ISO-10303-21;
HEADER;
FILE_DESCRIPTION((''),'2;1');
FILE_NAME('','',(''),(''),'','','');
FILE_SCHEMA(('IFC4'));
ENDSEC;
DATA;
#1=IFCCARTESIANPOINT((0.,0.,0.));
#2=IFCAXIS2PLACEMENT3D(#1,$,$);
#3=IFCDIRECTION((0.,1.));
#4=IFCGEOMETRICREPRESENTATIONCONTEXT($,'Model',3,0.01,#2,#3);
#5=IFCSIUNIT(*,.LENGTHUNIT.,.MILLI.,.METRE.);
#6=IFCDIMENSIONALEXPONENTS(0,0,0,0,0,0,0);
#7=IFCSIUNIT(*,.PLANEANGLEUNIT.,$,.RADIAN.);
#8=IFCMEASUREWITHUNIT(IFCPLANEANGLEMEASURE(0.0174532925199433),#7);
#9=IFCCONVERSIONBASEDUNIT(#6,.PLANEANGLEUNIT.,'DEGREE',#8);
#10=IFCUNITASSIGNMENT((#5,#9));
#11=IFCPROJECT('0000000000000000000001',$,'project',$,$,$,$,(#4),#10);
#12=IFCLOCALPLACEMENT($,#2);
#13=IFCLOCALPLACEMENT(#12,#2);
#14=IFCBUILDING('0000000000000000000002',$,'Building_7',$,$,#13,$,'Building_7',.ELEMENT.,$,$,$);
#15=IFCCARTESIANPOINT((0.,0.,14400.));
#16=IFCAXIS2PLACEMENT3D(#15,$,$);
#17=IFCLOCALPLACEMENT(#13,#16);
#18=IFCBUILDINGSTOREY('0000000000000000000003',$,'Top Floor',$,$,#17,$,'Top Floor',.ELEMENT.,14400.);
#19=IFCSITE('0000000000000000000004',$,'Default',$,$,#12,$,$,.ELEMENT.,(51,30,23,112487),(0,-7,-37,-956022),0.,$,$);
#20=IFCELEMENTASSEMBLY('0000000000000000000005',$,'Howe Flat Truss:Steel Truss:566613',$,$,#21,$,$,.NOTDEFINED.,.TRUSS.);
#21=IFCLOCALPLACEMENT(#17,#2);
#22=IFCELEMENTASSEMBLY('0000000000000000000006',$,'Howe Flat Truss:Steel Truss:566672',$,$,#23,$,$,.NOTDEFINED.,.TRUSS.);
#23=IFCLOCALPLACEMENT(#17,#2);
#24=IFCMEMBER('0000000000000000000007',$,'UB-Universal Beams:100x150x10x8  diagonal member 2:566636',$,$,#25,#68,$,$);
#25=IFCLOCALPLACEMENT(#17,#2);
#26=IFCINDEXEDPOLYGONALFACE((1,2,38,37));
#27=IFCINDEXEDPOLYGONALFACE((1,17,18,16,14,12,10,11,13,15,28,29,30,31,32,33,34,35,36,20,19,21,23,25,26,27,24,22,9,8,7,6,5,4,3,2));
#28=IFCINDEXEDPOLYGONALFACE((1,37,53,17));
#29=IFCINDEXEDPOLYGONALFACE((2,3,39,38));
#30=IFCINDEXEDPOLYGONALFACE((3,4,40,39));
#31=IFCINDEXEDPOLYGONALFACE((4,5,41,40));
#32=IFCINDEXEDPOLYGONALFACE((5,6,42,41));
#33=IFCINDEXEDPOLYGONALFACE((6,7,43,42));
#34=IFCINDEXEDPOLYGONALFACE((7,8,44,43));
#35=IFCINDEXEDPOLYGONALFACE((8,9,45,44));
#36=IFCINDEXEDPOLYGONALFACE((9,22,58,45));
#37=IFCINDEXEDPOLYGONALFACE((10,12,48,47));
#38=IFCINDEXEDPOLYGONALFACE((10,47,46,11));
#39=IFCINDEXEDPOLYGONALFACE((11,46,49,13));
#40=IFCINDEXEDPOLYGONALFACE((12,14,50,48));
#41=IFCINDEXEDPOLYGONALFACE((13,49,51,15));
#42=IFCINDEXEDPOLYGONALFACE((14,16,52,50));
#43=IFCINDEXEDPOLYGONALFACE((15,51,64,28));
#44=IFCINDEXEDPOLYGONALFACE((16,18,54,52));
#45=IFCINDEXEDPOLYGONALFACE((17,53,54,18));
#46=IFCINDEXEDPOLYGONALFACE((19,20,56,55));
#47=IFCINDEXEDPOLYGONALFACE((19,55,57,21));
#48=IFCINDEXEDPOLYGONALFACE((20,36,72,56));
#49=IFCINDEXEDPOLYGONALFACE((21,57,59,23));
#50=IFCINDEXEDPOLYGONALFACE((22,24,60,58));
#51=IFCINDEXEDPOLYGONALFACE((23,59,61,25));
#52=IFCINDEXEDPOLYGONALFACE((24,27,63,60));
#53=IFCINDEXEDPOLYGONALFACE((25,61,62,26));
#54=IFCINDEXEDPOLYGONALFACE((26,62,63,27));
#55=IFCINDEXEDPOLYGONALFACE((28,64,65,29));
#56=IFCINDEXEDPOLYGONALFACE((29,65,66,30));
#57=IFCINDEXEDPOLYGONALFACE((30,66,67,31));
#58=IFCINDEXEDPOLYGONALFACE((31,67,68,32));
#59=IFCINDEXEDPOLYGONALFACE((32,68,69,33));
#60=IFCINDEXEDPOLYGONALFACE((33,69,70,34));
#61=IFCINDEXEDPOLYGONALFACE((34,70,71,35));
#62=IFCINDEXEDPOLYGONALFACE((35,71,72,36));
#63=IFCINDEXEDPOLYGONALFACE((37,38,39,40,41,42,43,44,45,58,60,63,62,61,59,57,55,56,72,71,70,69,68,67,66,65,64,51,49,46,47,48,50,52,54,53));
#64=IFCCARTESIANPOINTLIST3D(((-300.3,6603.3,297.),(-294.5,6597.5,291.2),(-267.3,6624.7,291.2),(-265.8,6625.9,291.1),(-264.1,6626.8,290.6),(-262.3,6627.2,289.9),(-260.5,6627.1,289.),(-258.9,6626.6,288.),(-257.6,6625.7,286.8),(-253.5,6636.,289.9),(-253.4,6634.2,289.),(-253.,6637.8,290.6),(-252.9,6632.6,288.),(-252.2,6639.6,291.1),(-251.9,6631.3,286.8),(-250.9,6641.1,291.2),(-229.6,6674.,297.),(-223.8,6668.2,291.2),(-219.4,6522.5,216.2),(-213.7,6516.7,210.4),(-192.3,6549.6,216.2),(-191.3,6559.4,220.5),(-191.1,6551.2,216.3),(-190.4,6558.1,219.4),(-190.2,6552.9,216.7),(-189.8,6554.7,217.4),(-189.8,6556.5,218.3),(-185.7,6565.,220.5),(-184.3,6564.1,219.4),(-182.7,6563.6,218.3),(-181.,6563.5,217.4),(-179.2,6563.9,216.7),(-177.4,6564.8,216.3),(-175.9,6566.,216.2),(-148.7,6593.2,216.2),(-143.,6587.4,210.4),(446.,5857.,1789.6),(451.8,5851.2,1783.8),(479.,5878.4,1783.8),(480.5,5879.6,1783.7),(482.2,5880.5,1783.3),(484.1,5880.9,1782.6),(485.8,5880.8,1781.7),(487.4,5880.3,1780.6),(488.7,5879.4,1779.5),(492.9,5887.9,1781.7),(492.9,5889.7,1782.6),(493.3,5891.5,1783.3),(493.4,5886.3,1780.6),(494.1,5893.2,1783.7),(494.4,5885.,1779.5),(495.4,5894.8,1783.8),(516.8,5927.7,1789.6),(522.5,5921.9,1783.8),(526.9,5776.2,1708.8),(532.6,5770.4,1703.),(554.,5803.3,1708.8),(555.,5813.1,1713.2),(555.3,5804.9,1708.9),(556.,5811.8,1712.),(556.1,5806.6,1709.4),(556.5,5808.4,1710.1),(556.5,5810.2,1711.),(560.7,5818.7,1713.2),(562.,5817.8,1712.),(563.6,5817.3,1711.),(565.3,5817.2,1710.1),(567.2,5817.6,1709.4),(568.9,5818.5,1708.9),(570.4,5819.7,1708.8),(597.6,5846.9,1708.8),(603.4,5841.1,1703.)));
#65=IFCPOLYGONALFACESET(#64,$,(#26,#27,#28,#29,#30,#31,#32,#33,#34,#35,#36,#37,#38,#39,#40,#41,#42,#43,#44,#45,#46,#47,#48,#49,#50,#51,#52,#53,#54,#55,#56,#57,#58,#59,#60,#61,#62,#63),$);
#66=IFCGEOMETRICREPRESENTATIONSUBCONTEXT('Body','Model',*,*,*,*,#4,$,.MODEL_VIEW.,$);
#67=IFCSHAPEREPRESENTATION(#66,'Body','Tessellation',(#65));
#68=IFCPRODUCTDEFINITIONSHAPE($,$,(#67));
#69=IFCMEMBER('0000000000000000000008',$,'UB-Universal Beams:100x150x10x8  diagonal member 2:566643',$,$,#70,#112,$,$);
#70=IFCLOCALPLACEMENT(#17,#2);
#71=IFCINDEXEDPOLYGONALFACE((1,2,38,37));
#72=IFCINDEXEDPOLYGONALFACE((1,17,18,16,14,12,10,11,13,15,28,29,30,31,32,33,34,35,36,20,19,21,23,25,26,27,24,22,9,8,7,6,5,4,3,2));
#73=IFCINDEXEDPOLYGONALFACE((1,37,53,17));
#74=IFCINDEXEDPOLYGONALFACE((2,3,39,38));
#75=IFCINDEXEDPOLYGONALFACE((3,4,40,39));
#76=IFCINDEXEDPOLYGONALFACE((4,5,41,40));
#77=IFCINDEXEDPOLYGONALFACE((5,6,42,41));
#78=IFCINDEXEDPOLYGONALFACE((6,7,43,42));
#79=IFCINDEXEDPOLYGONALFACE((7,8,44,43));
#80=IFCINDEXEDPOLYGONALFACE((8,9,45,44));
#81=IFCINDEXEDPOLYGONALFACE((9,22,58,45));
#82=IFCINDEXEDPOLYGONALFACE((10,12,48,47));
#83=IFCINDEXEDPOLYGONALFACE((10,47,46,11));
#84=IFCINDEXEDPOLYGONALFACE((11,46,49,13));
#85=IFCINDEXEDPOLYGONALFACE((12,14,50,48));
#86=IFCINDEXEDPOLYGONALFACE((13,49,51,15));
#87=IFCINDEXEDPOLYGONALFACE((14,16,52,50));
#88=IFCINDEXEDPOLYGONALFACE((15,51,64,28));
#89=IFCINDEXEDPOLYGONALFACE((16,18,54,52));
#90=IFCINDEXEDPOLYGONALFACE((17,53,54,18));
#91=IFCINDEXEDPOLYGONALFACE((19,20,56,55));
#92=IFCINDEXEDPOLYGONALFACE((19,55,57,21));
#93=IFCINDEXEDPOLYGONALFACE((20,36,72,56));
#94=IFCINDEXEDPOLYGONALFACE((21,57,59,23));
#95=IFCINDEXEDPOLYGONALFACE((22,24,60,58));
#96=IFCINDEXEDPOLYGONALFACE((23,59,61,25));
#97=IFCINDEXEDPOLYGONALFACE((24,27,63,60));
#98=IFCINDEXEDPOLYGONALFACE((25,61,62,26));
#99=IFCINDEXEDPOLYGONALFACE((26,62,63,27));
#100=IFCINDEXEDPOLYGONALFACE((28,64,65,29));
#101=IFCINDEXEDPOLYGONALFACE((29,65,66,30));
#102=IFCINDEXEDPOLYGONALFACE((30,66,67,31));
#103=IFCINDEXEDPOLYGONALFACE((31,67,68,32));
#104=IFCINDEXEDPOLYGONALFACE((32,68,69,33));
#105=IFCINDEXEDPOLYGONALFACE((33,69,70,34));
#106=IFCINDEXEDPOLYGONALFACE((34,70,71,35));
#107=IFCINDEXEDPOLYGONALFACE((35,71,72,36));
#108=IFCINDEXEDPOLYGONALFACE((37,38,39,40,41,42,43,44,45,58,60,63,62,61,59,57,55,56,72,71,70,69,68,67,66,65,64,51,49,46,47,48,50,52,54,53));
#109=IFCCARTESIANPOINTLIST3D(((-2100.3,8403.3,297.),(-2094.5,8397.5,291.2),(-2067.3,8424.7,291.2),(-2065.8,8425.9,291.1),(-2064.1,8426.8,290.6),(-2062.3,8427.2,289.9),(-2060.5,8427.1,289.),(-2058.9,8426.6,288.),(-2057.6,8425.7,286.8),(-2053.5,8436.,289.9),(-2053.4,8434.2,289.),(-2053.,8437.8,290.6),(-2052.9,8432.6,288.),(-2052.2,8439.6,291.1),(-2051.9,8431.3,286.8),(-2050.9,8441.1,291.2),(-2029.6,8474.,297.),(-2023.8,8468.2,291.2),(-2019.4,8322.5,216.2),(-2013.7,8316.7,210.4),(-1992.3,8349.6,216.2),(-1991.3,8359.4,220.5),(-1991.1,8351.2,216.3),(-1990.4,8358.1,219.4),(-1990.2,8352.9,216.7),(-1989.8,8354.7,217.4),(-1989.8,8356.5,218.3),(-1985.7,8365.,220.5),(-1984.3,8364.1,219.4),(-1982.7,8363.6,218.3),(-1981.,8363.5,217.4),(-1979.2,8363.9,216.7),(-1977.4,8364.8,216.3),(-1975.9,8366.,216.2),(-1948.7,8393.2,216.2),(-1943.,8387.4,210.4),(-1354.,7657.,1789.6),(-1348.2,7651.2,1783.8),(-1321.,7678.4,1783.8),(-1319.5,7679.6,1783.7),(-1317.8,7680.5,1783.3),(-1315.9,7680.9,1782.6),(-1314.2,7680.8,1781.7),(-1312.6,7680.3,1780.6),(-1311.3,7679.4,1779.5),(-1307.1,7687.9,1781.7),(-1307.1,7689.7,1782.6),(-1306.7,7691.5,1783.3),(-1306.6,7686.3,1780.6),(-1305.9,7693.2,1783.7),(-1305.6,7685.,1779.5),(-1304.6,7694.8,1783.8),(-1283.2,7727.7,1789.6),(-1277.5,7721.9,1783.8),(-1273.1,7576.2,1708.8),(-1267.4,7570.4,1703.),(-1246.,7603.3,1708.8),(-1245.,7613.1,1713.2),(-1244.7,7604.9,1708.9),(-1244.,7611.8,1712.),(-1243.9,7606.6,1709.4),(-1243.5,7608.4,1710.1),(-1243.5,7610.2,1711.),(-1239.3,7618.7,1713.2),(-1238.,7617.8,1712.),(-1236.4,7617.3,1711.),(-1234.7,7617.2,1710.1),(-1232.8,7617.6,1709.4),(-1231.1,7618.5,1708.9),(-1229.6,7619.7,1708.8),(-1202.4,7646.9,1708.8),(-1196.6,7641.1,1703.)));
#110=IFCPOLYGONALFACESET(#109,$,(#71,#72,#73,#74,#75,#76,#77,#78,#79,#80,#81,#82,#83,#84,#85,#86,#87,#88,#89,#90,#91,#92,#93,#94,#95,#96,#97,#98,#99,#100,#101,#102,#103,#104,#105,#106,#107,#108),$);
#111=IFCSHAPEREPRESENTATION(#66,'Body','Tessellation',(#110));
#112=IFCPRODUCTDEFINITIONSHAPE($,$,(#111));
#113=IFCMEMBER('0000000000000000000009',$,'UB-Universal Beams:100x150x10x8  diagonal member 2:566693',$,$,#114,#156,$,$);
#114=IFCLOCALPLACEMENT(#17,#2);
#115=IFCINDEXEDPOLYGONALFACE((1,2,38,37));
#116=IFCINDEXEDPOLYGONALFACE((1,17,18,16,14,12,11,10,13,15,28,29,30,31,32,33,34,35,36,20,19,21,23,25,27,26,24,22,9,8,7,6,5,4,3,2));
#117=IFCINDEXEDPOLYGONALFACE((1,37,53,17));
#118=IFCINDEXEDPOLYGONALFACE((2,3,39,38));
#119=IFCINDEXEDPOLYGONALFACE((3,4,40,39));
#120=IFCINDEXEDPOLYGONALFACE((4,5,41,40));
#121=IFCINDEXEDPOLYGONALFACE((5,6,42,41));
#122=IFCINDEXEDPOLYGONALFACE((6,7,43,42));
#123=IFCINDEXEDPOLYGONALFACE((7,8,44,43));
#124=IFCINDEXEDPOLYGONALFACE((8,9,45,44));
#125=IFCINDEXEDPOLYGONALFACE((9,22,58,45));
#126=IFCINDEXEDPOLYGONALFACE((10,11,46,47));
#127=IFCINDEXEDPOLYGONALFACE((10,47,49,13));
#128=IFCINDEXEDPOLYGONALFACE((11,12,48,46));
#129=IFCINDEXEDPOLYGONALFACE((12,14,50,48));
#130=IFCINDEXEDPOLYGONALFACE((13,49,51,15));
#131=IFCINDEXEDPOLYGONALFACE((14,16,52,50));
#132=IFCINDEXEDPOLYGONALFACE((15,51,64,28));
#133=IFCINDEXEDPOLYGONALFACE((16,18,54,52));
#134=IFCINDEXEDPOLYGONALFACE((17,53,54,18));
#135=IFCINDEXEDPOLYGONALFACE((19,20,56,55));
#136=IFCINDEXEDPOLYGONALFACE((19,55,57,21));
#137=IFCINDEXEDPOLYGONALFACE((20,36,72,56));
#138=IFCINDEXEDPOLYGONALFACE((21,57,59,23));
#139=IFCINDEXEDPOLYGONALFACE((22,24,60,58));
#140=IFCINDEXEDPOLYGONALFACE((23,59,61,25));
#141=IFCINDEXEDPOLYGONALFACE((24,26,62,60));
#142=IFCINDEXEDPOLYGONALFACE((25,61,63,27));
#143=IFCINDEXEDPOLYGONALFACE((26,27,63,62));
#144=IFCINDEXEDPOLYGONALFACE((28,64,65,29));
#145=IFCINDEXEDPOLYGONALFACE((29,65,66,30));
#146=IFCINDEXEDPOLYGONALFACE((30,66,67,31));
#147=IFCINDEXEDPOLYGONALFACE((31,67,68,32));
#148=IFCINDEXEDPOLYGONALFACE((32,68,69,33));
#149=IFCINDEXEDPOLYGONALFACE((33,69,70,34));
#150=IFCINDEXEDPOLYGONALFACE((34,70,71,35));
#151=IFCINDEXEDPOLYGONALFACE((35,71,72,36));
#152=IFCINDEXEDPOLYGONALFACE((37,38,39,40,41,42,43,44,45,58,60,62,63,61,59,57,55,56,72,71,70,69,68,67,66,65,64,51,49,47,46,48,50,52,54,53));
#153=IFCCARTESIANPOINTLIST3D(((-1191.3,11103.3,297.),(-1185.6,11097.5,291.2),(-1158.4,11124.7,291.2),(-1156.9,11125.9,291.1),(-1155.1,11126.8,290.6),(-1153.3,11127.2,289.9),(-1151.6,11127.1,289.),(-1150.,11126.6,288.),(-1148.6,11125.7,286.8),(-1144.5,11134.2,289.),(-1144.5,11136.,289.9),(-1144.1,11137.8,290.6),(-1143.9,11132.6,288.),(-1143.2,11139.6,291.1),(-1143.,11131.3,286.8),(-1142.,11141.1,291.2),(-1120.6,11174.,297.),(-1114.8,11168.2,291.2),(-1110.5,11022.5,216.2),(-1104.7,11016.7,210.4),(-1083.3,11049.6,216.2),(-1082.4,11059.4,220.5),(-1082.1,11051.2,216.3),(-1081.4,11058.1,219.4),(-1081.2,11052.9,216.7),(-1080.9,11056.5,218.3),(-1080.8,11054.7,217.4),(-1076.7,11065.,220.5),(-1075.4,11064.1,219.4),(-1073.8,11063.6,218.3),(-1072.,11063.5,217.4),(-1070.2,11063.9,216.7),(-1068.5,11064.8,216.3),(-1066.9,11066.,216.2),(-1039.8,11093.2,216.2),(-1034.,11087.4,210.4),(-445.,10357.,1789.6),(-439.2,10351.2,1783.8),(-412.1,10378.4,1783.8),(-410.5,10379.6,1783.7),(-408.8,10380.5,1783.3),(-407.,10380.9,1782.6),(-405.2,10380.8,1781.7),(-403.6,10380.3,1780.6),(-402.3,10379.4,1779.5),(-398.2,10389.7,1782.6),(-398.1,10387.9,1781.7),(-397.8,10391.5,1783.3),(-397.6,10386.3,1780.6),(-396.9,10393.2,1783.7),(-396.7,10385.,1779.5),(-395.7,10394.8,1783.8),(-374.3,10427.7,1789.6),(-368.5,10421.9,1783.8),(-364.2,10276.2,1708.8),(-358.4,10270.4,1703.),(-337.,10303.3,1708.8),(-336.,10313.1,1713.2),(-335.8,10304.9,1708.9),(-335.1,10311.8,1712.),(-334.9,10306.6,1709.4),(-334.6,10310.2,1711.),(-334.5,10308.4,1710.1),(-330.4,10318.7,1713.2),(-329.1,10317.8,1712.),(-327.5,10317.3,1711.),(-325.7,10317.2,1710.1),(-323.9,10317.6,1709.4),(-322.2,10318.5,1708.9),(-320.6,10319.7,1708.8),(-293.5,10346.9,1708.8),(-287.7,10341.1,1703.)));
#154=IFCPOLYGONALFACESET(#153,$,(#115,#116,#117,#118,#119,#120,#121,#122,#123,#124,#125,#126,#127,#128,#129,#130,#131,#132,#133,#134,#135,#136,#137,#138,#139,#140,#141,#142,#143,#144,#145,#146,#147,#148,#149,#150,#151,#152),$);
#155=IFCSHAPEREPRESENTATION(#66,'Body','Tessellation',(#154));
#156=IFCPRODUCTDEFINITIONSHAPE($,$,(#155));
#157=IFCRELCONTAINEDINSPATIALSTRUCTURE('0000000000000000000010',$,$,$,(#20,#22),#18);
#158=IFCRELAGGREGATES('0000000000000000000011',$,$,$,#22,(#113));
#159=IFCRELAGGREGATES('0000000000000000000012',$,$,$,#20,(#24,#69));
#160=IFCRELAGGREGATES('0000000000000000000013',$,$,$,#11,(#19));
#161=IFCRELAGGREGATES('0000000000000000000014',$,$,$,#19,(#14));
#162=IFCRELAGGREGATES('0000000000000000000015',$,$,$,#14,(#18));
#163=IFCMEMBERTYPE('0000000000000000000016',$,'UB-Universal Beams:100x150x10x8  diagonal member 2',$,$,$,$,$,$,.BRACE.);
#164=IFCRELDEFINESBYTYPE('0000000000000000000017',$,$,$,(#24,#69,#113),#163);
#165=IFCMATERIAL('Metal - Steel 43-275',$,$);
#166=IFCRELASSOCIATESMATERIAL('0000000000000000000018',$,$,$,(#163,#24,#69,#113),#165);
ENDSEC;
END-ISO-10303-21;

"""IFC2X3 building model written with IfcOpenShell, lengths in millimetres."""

from ifc_helpers import new_model, entity, si_unit, converted_unit, direction, frame, frame_2d, origin, place, context, subcontext, project, spatial, polyline, circle_curve, parameter, trimmed, segment, composite_curve, outline, extrude, source, transform, mapped, material, type_object, type_shapes, element, aggregate, save


model = new_model("IFC2X3")

# Units and contexts
model_context = context("Model", 3, precision=0.01, world=origin(), true_north=direction((0.0, 1.0)))
body_context = subcontext(model_context, "Body", "Model", "MODEL_VIEW")
ifc_project = project(units=[si_unit("LENGTHUNIT", "METRE", prefix="MILLI"), converted_unit("PLANEANGLEUNIT", "DEGREE", entity("IfcPlaneAngleMeasure", 0.0174532925199433), si_unit("PLANEANGLEUNIT", "RADIAN"), dimensions=[0, 0, 0, 0, 0, 0, 0])], contexts=[model_context])

# Site, building, storey
site_placement = place(None, origin())
site = spatial("IfcSite", under=ifc_project, at=site_placement, Name="Default", CompositionType="ELEMENT", RefLatitude=(51, 30, 23, 112487), RefLongitude=(0, -7, -37, -956022), RefElevation=0.0)
building_placement = place(site_placement, origin())
building = spatial("IfcBuilding", under=site, at=building_placement, Name="Building_7", LongName="Building_7", CompositionType="ELEMENT")
storey_placement = place(building_placement, frame((0.0, 0.0, 14400.0)))
storey = spatial("IfcBuildingStorey", under=building, at=storey_placement, Name="Top Floor", LongName="Top Floor", CompositionType="ELEMENT", Elevation=14400.0)

# Shared definitions
ifc_material = material(Name="Metal - Steel 43-275")

# Element assemblies
assembly_1_placement = place(storey_placement, origin())
assembly_1 = element("IfcElementAssembly", 1, at=assembly_1_placement, inside=storey, Name="Howe Flat Truss:Steel Truss:566613", AssemblyPlace="NOTDEFINED", PredefinedType="TRUSS")
assembly_2_placement = place(storey_placement, origin())
assembly_2 = element("IfcElementAssembly", 2, at=assembly_2_placement, inside=storey, Name="Howe Flat Truss:Steel Truss:566672", AssemblyPlace="NOTDEFINED", PredefinedType="TRUSS")

# Members
member_type_1 = type_object("IfcMemberType", Name="UB-Universal Beams:100x150x10x8  diagonal member 2", PredefinedType="BRACE", material=ifc_material)
shared_shape_1 = source(origin(), body_context, "Body", "SweptSolid", [
    extrude(outline(composite_curve([segment(polyline([(-50.0, -65.0), (-50.0, -75.0)]), True, "CONTINUOUS"), segment(polyline([(-50.0, -75.0), (50.0, -75.0)]), True, "CONTINUOUS"), segment(polyline([(50.0, -75.0), (50.0, -65.0)]), True, "CONTINUOUS"), segment(polyline([(50.0, -65.0), (11.6, -65.0)]), True, "CONTINUOUS"), segment(trimmed(circle_curve(frame_2d((11.6, -57.4), x_axis=(1.0, 0.0)), 7.6), [parameter(180.0)], [parameter(270.0)], True, "PARAMETER"), False, "CONTINUOUS"), segment(polyline([(4.0, -57.4), (4.0, 57.4)]), True, "CONTINUOUS"), segment(trimmed(circle_curve(frame_2d((11.6, 57.4), x_axis=(1.0, 0.0)), 7.6), [parameter(90.0)], [parameter(180.0)], True, "PARAMETER"), False, "CONTINUOUS"), segment(polyline([(11.6, 65.0), (50.0, 65.0)]), True, "CONTINUOUS"), segment(polyline([(50.0, 65.0), (50.0, 75.0)]), True, "CONTINUOUS"), segment(polyline([(50.0, 75.0), (-50.0, 75.0)]), True, "CONTINUOUS"), segment(polyline([(-50.0, 75.0), (-50.0, 65.0)]), True, "CONTINUOUS"), segment(polyline([(-50.0, 65.0), (-11.6, 65.0)]), True, "CONTINUOUS"), segment(trimmed(circle_curve(frame_2d((-11.6, 57.4), x_axis=(1.0, 0.0)), 7.6), [parameter(360.0)], [parameter(90.0)], True, "PARAMETER"), False, "CONTINUOUS"), segment(polyline([(-4.0, 57.4), (-4.0, -57.4)]), True, "CONTINUOUS"), segment(trimmed(circle_curve(frame_2d((-11.6, -57.4), x_axis=(1.0, 0.0)), 7.6), [parameter(270.0)], [parameter(360.0)], True, "PARAMETER"), False, "CONTINUOUS"), segment(polyline([(-11.6, -65.0), (-50.0, -65.0)]), True, "CONTINUOUS")], self_intersect=False)), frame((-914.0, 0.0, 0.0), z_axis=(-1.0, 0.0, 0.0), x_axis=(0.0, -1.0, 0.0)), (0.0, 0.0, -1.0), 1828.1),
])
type_shapes(member_type_1, [shared_shape_1])
member_1_placement = place(assembly_1_placement, frame((151.5, 6222.2, 1000.0), z_axis=(0.57735, -0.57735, -0.57735), x_axis=(0.408248, -0.408248, 0.816497)))
member_1 = element("IfcMember", 3, at=member_1_placement, type_object=member_type_1, material=ifc_material, Name="UB-Universal Beams:100x150x10x8  diagonal member 2:566636", context=body_context, shape_type="MappedRepresentation", body=[
    mapped(shared_shape_1, transform((0.0, 0.0, 0.0), scale=1.0)),
])
member_2_placement = place(assembly_1_placement, frame((-1648.5, 8022.2, 1000.0), z_axis=(0.57735, -0.57735, -0.57735), x_axis=(0.408248, -0.408248, 0.816497)))
member_2 = element("IfcMember", 4, at=member_2_placement, type_object=member_type_1, material=ifc_material, Name="UB-Universal Beams:100x150x10x8  diagonal member 2:566643", context=body_context, shape_type="MappedRepresentation", body=[
    mapped(shared_shape_1, transform((0.0, 0.0, 0.0), scale=1.0)),
])
member_3_placement = place(assembly_2_placement, frame((-739.5, 10722.2, 1000.0), z_axis=(0.57735, -0.57735, -0.57735), x_axis=(-0.408248, 0.408248, -0.816497)))
member_3 = element("IfcMember", 5, at=member_3_placement, type_object=member_type_1, material=ifc_material, Name="UB-Universal Beams:100x150x10x8  diagonal member 2:566693", context=body_context, shape_type="MappedRepresentation", body=[
    mapped(shared_shape_1, transform((0.0, 0.0, 0.0), scale=1.0)),
])
aggregate(assembly_2, [member_3])
aggregate(assembly_1, [member_1, member_2])

save(model, "model.ifc")
